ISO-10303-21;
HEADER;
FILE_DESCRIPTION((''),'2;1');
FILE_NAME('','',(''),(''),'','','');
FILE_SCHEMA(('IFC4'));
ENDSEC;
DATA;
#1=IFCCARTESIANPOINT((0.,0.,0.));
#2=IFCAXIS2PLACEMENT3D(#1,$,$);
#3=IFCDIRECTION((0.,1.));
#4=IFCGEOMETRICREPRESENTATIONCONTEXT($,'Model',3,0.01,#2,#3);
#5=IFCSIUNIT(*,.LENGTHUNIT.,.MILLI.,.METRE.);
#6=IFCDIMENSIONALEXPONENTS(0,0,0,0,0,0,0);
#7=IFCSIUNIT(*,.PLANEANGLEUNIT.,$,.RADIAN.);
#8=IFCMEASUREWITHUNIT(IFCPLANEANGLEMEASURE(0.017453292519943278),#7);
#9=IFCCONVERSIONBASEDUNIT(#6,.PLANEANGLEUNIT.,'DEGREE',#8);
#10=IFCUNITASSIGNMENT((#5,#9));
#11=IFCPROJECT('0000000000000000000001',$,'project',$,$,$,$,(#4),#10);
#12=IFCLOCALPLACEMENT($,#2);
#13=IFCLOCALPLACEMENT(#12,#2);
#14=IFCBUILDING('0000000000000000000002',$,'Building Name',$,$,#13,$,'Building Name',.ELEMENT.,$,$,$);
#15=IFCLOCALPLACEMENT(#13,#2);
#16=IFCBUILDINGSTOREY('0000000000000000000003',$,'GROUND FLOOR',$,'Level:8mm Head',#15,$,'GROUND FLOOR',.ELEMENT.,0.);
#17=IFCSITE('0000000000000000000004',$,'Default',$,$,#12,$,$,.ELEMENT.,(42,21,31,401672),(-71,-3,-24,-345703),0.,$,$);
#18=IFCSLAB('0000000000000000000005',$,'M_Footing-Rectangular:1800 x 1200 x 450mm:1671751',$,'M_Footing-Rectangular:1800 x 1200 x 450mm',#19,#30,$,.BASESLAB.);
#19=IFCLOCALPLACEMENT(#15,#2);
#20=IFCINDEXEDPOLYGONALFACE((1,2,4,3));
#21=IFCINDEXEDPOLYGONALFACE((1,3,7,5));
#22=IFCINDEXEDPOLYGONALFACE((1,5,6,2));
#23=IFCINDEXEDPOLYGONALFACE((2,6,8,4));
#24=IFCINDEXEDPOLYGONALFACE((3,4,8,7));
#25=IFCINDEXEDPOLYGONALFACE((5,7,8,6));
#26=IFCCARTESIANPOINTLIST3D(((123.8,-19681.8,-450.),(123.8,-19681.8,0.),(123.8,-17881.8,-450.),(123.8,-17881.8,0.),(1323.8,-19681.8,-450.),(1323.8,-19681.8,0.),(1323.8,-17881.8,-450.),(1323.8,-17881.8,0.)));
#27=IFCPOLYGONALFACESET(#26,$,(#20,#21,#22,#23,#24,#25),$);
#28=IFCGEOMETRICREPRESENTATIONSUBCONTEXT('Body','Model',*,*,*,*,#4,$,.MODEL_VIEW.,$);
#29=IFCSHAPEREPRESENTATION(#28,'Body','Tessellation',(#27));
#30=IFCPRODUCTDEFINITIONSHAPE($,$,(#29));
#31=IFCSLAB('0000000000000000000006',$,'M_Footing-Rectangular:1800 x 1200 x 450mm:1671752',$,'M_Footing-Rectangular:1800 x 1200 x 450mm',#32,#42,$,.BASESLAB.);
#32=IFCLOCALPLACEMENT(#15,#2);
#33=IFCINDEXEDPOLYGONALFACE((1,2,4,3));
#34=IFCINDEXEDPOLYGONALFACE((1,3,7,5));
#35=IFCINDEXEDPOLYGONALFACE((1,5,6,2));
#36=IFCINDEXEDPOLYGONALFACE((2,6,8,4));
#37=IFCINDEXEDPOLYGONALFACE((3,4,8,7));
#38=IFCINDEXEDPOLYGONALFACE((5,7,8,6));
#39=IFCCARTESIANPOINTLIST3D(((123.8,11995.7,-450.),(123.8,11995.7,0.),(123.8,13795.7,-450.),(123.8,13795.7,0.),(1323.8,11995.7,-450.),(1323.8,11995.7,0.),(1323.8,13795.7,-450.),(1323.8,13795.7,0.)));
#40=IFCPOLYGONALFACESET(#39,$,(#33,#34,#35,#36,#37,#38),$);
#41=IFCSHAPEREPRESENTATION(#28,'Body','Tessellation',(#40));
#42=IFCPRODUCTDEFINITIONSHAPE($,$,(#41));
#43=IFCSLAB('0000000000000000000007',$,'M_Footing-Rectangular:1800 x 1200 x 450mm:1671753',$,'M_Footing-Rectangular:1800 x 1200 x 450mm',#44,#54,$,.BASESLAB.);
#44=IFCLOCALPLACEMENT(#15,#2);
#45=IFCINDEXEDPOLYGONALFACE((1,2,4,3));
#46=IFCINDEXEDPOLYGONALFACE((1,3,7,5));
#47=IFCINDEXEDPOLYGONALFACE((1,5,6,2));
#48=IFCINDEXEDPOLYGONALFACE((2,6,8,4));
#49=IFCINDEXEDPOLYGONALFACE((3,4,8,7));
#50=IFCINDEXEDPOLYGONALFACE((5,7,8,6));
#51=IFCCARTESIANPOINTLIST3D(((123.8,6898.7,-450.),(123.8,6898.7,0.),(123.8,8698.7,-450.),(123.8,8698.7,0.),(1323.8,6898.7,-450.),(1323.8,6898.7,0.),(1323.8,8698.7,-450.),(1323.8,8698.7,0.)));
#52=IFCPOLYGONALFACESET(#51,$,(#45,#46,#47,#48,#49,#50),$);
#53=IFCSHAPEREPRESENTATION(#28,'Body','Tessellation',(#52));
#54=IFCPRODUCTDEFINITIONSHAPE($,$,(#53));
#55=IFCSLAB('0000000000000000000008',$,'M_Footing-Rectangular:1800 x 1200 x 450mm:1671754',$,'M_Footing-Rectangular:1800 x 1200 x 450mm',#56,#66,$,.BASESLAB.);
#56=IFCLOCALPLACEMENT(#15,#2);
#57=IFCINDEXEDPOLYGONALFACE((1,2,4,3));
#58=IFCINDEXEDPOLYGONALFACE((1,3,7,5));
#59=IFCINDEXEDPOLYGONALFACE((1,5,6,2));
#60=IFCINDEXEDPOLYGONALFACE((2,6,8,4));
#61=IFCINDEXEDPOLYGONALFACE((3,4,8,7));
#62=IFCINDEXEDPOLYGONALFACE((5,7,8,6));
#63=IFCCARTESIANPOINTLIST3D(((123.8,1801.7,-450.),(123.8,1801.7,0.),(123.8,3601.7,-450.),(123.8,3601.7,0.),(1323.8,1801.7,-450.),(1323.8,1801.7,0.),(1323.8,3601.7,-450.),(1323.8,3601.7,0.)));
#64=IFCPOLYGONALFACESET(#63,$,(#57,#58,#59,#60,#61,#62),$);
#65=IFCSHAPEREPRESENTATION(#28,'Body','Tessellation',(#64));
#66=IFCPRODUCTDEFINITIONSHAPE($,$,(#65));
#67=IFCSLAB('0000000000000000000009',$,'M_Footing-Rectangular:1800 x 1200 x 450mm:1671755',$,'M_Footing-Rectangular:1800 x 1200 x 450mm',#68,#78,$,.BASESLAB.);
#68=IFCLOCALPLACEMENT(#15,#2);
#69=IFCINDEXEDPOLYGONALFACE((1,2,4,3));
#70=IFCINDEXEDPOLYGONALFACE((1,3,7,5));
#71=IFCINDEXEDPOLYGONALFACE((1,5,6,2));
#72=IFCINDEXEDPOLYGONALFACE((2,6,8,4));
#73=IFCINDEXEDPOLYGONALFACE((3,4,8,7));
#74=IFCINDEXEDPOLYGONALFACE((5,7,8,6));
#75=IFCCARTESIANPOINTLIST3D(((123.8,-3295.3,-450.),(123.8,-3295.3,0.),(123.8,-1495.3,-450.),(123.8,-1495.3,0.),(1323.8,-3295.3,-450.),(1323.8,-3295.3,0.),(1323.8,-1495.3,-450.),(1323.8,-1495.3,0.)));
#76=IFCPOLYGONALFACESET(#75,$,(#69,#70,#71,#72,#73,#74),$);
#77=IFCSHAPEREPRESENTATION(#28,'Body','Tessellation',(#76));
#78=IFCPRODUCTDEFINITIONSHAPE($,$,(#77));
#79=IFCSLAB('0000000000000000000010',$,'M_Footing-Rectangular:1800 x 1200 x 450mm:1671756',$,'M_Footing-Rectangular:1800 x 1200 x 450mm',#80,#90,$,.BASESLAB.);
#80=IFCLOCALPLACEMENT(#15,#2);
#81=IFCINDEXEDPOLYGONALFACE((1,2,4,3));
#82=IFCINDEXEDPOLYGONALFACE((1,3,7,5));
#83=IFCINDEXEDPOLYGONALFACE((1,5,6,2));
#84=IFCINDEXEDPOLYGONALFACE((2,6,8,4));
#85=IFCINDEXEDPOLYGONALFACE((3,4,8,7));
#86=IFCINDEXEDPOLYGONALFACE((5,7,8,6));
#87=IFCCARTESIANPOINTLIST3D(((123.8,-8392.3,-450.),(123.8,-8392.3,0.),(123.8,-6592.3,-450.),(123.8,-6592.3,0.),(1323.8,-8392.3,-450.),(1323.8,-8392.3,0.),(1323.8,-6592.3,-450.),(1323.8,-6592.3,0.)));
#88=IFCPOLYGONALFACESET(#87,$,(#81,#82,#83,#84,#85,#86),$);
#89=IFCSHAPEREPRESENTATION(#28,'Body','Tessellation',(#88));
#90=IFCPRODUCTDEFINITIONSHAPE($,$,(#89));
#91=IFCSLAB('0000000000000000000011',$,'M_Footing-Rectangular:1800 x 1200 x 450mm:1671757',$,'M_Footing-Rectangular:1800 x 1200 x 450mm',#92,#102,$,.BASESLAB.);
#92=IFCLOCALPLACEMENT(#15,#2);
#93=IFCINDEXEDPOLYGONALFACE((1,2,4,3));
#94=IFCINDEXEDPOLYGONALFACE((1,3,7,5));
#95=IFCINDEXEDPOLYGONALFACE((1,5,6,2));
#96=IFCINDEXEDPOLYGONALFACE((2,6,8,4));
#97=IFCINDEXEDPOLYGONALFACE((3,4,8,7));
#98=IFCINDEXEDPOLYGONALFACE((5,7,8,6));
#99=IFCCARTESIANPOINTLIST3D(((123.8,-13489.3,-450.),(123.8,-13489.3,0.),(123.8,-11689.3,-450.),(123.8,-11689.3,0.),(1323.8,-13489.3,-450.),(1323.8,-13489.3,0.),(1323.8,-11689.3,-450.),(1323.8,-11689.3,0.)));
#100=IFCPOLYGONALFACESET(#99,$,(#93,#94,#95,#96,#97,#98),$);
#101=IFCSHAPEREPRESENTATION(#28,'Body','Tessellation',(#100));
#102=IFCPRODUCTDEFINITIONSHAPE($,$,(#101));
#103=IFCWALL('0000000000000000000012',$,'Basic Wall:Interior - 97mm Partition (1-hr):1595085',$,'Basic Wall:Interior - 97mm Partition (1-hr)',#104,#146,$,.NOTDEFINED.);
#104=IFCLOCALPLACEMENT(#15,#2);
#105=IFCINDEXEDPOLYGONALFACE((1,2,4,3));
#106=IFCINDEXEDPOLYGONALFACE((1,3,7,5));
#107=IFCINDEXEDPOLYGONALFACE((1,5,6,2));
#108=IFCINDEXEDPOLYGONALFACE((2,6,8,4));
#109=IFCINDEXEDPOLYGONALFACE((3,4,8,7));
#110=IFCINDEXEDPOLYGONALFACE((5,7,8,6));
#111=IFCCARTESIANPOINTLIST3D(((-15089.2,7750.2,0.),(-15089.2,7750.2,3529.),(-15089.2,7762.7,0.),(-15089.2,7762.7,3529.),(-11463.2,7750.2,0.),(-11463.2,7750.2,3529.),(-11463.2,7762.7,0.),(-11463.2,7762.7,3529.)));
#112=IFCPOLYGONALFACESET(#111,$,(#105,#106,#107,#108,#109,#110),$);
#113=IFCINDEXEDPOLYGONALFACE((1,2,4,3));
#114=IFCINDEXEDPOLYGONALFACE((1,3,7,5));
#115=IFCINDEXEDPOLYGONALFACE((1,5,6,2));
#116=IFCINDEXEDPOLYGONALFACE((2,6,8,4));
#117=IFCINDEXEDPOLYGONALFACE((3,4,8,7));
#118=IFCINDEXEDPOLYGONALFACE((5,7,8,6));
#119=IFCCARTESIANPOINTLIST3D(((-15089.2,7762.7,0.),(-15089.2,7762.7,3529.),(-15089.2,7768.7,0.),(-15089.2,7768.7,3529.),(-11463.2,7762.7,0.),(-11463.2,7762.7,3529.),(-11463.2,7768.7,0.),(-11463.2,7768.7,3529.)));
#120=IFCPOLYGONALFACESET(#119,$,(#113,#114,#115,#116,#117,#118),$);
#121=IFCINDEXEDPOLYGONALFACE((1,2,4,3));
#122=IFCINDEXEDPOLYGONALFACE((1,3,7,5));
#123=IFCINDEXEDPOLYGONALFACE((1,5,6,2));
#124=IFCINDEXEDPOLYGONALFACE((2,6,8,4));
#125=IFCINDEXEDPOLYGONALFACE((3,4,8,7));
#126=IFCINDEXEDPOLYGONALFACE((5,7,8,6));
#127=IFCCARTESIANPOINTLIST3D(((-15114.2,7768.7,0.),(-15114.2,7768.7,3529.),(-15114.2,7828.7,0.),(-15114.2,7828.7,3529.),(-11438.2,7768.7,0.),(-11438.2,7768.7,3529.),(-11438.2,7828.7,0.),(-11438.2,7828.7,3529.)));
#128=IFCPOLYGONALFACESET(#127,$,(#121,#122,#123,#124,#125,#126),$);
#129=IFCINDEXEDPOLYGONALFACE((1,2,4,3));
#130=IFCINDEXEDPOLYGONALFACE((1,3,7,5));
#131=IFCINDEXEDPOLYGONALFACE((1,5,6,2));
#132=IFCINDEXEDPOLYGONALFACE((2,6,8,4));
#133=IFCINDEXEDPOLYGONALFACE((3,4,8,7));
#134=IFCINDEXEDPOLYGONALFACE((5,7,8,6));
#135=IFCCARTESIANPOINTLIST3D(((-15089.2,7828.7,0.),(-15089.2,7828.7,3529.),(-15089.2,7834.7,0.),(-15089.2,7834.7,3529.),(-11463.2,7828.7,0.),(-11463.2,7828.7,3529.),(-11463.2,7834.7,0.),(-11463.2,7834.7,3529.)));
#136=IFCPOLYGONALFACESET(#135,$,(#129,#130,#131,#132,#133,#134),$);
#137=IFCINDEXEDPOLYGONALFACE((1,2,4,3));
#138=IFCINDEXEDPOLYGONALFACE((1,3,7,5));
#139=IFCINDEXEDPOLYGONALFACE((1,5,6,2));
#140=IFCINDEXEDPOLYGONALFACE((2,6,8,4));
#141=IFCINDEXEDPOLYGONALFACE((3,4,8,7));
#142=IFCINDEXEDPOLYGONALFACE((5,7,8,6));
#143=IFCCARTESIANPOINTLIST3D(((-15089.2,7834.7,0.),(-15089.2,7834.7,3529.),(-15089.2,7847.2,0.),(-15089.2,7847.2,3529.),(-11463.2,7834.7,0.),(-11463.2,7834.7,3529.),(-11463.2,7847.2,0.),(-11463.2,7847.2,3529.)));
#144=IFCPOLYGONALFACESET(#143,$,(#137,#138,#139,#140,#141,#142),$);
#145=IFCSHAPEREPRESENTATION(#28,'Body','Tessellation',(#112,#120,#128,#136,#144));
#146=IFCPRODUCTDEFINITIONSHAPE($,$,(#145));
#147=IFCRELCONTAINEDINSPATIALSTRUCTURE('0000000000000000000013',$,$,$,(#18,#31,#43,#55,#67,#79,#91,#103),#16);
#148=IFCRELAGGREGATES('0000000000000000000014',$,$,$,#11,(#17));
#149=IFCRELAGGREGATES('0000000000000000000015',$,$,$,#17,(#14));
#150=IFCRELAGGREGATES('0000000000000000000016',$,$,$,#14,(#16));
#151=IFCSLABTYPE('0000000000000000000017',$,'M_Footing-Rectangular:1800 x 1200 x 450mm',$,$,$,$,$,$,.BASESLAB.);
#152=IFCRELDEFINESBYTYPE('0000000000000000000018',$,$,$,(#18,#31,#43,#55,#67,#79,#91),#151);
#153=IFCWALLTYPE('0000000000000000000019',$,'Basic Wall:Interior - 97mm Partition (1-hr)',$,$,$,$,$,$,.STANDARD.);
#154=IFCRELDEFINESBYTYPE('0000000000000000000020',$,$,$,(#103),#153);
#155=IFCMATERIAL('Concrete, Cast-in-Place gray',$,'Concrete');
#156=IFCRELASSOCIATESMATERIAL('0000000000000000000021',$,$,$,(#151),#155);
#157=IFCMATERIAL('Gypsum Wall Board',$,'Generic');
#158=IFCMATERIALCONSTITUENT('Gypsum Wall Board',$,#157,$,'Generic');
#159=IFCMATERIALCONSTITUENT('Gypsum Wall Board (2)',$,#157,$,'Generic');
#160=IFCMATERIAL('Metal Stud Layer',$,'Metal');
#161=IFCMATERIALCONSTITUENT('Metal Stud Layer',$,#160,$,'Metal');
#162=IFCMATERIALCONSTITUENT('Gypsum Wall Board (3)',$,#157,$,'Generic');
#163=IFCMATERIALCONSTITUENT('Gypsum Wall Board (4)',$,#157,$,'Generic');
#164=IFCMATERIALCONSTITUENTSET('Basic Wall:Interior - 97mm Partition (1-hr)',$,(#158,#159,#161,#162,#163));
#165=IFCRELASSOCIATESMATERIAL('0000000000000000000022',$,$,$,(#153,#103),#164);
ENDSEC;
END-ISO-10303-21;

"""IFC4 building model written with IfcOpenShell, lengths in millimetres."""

from ifc_helpers import new_model, entity, si_unit, converted_unit, direction, frame, origin, place, context, subcontext, project, spatial, indexed_curve, outline, extrude, material, constituent, constituent_set, type_object, element, save


model = new_model("IFC4")

# Units and contexts
model_context = context("Model", 3, precision=0.01, world=origin(), true_north=direction((0.0, 1.0)))
body_context = subcontext(model_context, "Body", "Model", "MODEL_VIEW")
ifc_project = project(units=[si_unit("LENGTHUNIT", "METRE", prefix="MILLI"), converted_unit("PLANEANGLEUNIT", "DEGREE", entity("IfcPlaneAngleMeasure", 0.017453292519943278), si_unit("PLANEANGLEUNIT", "RADIAN"), dimensions=[0, 0, 0, 0, 0, 0, 0])], contexts=[model_context])

# Site, building, storey
site_placement = place(None, origin())
site = spatial("IfcSite", under=ifc_project, at=site_placement, Name="Default", CompositionType="ELEMENT", RefLatitude=(42, 21, 31, 401672), RefLongitude=(-71, -3, -24, -345703), RefElevation=0.0)
building_placement = place(site_placement, origin())
building = spatial("IfcBuilding", under=site, at=building_placement, Name="Building Name", LongName="Building Name", CompositionType="ELEMENT")
storey_placement = place(building_placement, origin())
storey = spatial("IfcBuildingStorey", under=building, at=storey_placement, Name="GROUND FLOOR", ObjectType="Level:8mm Head", LongName="GROUND FLOOR", CompositionType="ELEMENT", Elevation=0.0)

# Slabs
ifc_material_1 = material(Name="Concrete, Cast-in-Place gray", Category="Concrete")
slab_type = type_object("IfcSlabType", Name="M_Footing-Rectangular:1800 x 1200 x 450mm", PredefinedType="BASESLAB", material=ifc_material_1)
slab_1_placement = place(storey_placement, origin())
element("IfcSlab", 1, at=slab_1_placement, inside=storey, type_object=slab_type, Name="M_Footing-Rectangular:1800 x 1200 x 450mm:1671751", ObjectType="M_Footing-Rectangular:1800 x 1200 x 450mm", PredefinedType="BASESLAB", context=body_context, shape_type="SweptSolid", body=[
    extrude(outline(indexed_curve([(-600.0, -900.0), (600.0, -900.0), (600.0, 900.0), (-600.0, 900.0), (-600.0, -900.0)], self_intersect=False)), frame((723.8, -18781.8, -450.0)), (0.0, 0.0, 1.0), 450.0),
])
slab_2_placement = place(storey_placement, origin())
element("IfcSlab", 2, at=slab_2_placement, inside=storey, type_object=slab_type, Name="M_Footing-Rectangular:1800 x 1200 x 450mm:1671752", ObjectType="M_Footing-Rectangular:1800 x 1200 x 450mm", PredefinedType="BASESLAB", context=body_context, shape_type="SweptSolid", body=[
    extrude(outline(indexed_curve([(-600.0, -900.0), (600.0, -900.0), (600.0, 900.0), (-600.0, 900.0), (-600.0, -900.0)], self_intersect=False)), frame((723.8, 12895.7, -450.0)), (0.0, 0.0, 1.0), 450.0),
])
slab_3_placement = place(storey_placement, origin())
element("IfcSlab", 3, at=slab_3_placement, inside=storey, type_object=slab_type, Name="M_Footing-Rectangular:1800 x 1200 x 450mm:1671753", ObjectType="M_Footing-Rectangular:1800 x 1200 x 450mm", PredefinedType="BASESLAB", context=body_context, shape_type="SweptSolid", body=[
    extrude(outline(indexed_curve([(-600.0, -900.0), (600.0, -900.0), (600.0, 900.0), (-600.0, 900.0), (-600.0, -900.0)], self_intersect=False)), frame((723.8, 7798.7, -450.0)), (0.0, 0.0, 1.0), 450.0),
])
slab_4_placement = place(storey_placement, origin())
element("IfcSlab", 4, at=slab_4_placement, inside=storey, type_object=slab_type, Name="M_Footing-Rectangular:1800 x 1200 x 450mm:1671754", ObjectType="M_Footing-Rectangular:1800 x 1200 x 450mm", PredefinedType="BASESLAB", context=body_context, shape_type="SweptSolid", body=[
    extrude(outline(indexed_curve([(-600.0, -900.0), (600.0, -900.0), (600.0, 900.0), (-600.0, 900.0), (-600.0, -900.0)], self_intersect=False)), frame((723.8, 2701.7, -450.0)), (0.0, 0.0, 1.0), 450.0),
])
slab_5_placement = place(storey_placement, origin())
element("IfcSlab", 5, at=slab_5_placement, inside=storey, type_object=slab_type, Name="M_Footing-Rectangular:1800 x 1200 x 450mm:1671755", ObjectType="M_Footing-Rectangular:1800 x 1200 x 450mm", PredefinedType="BASESLAB", context=body_context, shape_type="SweptSolid", body=[
    extrude(outline(indexed_curve([(-600.0, -900.0), (600.0, -900.0), (600.0, 900.0), (-600.0, 900.0), (-600.0, -900.0)], self_intersect=False)), frame((723.8, -2395.3, -450.0)), (0.0, 0.0, 1.0), 450.0),
])
slab_6_placement = place(storey_placement, origin())
element("IfcSlab", 6, at=slab_6_placement, inside=storey, type_object=slab_type, Name="M_Footing-Rectangular:1800 x 1200 x 450mm:1671756", ObjectType="M_Footing-Rectangular:1800 x 1200 x 450mm", PredefinedType="BASESLAB", context=body_context, shape_type="SweptSolid", body=[
    extrude(outline(indexed_curve([(-600.0, -900.0), (600.0, -900.0), (600.0, 900.0), (-600.0, 900.0), (-600.0, -900.0)], self_intersect=False)), frame((723.8, -7492.3, -450.0)), (0.0, 0.0, 1.0), 450.0),
])
slab_7_placement = place(storey_placement, origin())
element("IfcSlab", 7, at=slab_7_placement, inside=storey, type_object=slab_type, Name="M_Footing-Rectangular:1800 x 1200 x 450mm:1671757", ObjectType="M_Footing-Rectangular:1800 x 1200 x 450mm", PredefinedType="BASESLAB", context=body_context, shape_type="SweptSolid", body=[
    extrude(outline(indexed_curve([(-600.0, -900.0), (600.0, -900.0), (600.0, 900.0), (-600.0, 900.0), (-600.0, -900.0)], self_intersect=False)), frame((723.8, -12589.3, -450.0)), (0.0, 0.0, 1.0), 450.0),
])

# Wall
ifc_material_2 = material(Name="Gypsum Wall Board", Category="Generic")
ifc_constituent_1 = constituent(ifc_material_2, Name="Gypsum Wall Board", Category="Generic")
ifc_constituent_2 = constituent(ifc_material_2, Name="Gypsum Wall Board (2)", Category="Generic")
ifc_material_3 = material(Name="Metal Stud Layer", Category="Metal")
ifc_constituent_3 = constituent(ifc_material_3, Name="Metal Stud Layer", Category="Metal")
ifc_constituent_4 = constituent(ifc_material_2, Name="Gypsum Wall Board (3)", Category="Generic")
ifc_constituent_5 = constituent(ifc_material_2, Name="Gypsum Wall Board (4)", Category="Generic")
ifc_constituent_set_1 = constituent_set(constituents=[ifc_constituent_1, ifc_constituent_2, ifc_constituent_3, ifc_constituent_4, ifc_constituent_5], Name="Basic Wall:Interior - 97mm Partition (1-hr)")
wall_type_1 = type_object("IfcWallType", Name="Basic Wall:Interior - 97mm Partition (1-hr)", PredefinedType="STANDARD", material=ifc_constituent_set_1)
wall_1_placement = place(storey_placement, frame((-15089.2, 7798.7, 0.0)))
element("IfcWall", 8, at=wall_1_placement, inside=storey, type_object=wall_type_1, material=ifc_constituent_set_1, Name="Basic Wall:Interior - 97mm Partition (1-hr):1595085", ObjectType="Basic Wall:Interior - 97mm Partition (1-hr)", PredefinedType="NOTDEFINED", context=body_context, shape_type="SweptSolid", body=[
    extrude(outline(indexed_curve([(-6.3, -1813.0), (6.2, -1813.0), (6.3, 1813.0), (-6.2, 1813.0), (-6.3, -1813.0)], self_intersect=False)), frame((1813.0, -42.3, 0.0), z_axis=(0.0, 0.0, 1.0), x_axis=(0.0, 1.0, 0.0)), (0.0, 0.0, 1.0), 3529.0),
    extrude(outline(indexed_curve([(-1813.0, -3.0), (1813.0, -3.0), (1813.0, 3.0), (-1813.0, 3.0), (-1813.0, -3.0)], self_intersect=False)), frame((1813.0, -33.0, 0.0)), (0.0, 0.0, 1.0), 3529.0),
    extrude(outline(indexed_curve([(-1838.0, -30.0), (1838.0, -30.0), (1838.0, 30.0), (-1838.0, 30.0), (-1838.0, -30.0)], self_intersect=False)), frame((1813.0, 0.0, 0.0)), (0.0, 0.0, 1.0), 3529.0),
    extrude(outline(indexed_curve([(-1813.0, -3.0), (1813.0, -3.0), (1813.0, 3.0), (-1813.0, 3.0), (-1813.0, -3.0)], self_intersect=False)), frame((1813.0, 33.0, 0.0)), (0.0, 0.0, 1.0), 3529.0),
    extrude(outline(indexed_curve([(-6.3, -1813.0), (6.2, -1813.0), (6.3, 1813.0), (-6.2, 1813.0), (-6.3, -1813.0)], self_intersect=False)), frame((1813.0, 42.3, 0.0), z_axis=(0.0, 0.0, 1.0), x_axis=(0.0, -1.0, 0.0)), (0.0, 0.0, 1.0), 3529.0),
])

save(model, "model.ifc")
